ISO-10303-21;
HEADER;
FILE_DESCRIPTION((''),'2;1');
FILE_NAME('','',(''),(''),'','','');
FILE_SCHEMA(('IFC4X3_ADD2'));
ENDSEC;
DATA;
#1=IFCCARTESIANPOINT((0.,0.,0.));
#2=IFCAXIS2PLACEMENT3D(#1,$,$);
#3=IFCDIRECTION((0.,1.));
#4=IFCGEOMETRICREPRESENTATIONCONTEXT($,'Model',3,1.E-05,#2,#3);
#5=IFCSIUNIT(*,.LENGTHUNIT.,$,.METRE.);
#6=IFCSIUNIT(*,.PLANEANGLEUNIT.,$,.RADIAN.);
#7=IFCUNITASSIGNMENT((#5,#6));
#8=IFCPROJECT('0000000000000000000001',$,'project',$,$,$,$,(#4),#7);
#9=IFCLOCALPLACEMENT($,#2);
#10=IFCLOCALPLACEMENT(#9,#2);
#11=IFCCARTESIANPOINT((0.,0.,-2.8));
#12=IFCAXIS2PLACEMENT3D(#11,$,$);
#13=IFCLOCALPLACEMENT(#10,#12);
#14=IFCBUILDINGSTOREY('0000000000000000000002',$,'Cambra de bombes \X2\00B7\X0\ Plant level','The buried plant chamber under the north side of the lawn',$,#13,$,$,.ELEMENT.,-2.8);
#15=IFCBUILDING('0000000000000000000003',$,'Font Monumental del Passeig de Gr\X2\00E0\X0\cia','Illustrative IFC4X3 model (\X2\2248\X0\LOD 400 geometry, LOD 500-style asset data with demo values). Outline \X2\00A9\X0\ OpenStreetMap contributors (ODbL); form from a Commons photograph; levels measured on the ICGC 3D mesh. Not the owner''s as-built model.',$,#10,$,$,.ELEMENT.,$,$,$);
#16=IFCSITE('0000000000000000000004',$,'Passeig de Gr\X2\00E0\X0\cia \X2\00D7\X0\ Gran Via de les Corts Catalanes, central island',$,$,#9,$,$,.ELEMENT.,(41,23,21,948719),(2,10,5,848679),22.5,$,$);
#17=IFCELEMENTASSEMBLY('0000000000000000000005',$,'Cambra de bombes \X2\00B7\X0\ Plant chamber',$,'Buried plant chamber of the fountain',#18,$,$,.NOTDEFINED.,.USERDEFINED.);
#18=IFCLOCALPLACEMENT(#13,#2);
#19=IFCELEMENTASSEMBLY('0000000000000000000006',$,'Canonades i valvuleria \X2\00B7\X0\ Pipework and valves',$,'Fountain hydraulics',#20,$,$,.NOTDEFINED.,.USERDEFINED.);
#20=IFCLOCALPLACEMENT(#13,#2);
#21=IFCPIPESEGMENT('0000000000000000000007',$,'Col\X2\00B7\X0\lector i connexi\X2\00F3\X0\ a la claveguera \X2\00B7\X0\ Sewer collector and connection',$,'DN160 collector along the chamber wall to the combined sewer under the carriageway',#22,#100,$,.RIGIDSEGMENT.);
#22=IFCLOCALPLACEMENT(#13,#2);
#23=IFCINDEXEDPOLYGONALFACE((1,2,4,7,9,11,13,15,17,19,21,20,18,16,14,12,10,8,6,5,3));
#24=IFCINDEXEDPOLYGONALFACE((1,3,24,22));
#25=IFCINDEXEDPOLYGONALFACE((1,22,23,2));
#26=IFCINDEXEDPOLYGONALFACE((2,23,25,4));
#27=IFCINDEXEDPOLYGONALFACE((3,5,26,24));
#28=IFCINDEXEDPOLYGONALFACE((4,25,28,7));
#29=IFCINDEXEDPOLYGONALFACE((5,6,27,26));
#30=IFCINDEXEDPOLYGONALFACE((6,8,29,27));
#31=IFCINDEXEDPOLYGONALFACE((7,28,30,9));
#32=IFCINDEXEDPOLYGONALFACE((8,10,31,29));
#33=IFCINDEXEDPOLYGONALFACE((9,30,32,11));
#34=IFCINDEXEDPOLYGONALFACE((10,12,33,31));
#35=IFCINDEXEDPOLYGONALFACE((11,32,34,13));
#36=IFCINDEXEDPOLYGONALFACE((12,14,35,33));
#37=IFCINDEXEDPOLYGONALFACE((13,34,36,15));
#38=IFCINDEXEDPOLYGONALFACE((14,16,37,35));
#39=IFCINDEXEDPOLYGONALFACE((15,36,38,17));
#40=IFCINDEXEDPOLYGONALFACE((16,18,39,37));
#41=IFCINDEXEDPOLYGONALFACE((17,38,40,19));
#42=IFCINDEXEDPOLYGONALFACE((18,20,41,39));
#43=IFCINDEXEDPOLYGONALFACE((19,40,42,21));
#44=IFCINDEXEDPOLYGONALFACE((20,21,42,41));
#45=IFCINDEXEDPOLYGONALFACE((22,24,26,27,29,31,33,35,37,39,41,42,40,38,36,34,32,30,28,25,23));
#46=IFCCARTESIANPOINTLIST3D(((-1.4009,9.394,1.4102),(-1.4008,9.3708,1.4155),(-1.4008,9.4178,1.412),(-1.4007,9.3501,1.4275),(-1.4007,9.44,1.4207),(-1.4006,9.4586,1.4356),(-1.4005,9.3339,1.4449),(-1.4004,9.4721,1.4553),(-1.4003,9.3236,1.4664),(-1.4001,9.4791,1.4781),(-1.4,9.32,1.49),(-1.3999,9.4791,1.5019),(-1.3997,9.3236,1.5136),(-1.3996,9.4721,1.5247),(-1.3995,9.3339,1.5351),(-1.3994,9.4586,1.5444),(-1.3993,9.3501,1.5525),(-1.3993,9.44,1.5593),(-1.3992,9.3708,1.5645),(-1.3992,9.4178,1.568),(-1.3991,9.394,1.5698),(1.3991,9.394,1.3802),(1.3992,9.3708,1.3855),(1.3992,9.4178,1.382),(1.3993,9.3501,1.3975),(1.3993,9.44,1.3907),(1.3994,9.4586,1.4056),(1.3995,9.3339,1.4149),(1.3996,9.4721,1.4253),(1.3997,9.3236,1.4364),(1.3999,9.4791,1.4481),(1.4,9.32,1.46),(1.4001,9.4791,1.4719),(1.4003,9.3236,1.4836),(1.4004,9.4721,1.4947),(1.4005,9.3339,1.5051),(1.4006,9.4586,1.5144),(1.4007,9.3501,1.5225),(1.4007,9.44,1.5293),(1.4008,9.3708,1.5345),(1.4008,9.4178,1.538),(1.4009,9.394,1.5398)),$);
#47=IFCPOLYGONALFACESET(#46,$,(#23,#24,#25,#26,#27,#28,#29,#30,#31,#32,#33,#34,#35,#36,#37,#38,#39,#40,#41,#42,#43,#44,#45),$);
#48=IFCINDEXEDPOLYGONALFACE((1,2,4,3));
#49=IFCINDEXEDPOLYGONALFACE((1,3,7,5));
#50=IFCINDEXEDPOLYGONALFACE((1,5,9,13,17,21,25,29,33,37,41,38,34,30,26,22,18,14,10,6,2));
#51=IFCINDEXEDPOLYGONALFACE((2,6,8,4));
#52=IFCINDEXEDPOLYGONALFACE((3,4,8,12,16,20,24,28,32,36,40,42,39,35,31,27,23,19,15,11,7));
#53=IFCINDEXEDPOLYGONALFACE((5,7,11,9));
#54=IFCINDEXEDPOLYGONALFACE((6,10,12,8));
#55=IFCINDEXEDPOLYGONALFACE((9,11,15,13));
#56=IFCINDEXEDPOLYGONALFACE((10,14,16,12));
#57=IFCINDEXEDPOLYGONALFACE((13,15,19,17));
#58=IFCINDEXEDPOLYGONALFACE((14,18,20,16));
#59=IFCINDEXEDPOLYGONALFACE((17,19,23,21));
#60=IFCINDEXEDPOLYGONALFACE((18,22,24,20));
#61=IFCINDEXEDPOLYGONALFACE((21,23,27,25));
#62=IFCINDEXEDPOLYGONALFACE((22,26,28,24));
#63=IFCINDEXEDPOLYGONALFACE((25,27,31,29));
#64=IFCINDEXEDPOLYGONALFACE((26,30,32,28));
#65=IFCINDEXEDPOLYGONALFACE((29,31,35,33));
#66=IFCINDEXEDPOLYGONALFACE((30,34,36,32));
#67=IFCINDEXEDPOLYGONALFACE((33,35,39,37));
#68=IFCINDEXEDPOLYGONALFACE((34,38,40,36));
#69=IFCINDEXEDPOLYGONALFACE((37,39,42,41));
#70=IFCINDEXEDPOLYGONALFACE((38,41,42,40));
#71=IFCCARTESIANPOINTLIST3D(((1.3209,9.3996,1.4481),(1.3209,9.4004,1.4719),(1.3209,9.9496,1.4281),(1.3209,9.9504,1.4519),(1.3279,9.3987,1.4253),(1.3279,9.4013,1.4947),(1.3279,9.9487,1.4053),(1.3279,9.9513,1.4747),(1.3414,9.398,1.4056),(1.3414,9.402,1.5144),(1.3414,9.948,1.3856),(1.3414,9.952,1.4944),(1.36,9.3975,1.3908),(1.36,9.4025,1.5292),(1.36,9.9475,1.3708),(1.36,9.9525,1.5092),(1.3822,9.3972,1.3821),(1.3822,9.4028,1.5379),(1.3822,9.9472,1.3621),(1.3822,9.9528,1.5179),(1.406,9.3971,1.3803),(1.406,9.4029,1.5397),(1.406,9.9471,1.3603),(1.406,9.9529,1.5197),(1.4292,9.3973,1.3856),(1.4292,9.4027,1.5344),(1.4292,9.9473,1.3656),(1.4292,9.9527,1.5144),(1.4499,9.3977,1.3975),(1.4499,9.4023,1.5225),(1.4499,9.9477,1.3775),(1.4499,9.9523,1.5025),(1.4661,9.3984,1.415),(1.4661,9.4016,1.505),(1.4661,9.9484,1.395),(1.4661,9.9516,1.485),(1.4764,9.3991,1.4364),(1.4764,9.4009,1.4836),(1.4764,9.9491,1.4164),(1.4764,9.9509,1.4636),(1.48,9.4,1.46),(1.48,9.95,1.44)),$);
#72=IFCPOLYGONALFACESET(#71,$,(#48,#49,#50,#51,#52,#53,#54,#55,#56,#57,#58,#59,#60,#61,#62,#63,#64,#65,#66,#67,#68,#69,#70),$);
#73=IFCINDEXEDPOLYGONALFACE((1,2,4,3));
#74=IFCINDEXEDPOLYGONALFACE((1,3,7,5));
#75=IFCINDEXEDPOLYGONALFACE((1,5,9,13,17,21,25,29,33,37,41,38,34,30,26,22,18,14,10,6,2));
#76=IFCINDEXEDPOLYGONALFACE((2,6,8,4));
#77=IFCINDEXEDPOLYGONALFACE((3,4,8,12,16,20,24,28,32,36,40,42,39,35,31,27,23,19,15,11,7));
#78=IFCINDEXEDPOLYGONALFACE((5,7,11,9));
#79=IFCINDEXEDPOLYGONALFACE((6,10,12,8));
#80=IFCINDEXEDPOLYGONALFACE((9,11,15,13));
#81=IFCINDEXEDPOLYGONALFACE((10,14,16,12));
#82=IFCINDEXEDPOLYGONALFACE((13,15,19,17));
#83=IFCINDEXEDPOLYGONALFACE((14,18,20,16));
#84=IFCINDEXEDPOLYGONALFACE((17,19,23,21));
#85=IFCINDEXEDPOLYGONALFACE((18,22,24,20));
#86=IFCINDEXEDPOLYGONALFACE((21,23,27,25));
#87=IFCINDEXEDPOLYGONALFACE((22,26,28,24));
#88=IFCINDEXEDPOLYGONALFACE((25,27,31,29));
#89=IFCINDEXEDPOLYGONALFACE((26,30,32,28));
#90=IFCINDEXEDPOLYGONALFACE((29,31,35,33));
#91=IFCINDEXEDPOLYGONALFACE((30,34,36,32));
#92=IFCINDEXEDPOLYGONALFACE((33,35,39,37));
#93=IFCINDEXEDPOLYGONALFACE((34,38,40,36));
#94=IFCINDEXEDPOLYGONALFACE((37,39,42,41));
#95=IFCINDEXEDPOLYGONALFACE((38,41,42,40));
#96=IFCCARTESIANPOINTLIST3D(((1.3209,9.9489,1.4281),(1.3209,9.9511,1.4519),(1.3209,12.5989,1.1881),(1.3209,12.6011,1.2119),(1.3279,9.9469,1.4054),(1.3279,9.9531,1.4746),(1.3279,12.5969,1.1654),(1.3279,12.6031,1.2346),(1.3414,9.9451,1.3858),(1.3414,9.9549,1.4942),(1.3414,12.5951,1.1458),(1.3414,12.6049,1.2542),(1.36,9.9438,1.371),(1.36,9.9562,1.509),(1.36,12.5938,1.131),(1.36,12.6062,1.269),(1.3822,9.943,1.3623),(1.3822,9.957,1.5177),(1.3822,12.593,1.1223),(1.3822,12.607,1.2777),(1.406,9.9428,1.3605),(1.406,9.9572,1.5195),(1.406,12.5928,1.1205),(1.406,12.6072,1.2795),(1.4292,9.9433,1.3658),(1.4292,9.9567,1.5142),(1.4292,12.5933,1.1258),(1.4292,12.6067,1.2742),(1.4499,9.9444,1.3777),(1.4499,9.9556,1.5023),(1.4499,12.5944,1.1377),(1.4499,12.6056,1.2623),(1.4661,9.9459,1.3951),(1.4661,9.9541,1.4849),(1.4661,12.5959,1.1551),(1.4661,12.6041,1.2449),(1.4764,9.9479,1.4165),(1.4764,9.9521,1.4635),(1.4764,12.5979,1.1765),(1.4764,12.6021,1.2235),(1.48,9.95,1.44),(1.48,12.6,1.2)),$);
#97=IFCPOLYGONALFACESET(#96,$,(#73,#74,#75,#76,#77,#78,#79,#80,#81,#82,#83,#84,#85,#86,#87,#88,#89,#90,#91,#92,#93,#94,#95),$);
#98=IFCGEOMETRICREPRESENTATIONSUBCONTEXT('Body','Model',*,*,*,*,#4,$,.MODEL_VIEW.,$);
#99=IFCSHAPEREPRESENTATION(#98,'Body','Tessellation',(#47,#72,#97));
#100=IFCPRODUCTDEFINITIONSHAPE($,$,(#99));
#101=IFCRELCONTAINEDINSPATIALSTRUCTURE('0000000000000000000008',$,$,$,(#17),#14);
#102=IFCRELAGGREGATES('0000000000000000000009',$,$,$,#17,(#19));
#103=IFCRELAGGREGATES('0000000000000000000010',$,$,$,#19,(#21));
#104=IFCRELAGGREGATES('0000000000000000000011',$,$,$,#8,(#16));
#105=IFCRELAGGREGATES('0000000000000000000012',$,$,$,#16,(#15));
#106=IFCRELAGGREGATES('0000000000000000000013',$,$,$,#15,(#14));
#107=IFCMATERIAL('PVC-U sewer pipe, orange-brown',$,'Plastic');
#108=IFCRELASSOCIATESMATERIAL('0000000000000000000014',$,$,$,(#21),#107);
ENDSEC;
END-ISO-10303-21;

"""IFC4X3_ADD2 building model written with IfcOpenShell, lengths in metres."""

from ifc_helpers import new_model, si_unit, direction, frame, origin, origin_2d_with_axis, place, context, subcontext, project, spatial, circle, extrude, material, element, aggregate, save


model = new_model("IFC4X3_ADD2")

# Units and contexts
model_context = context("Model", 3, precision=1e-05, world=origin(), true_north=direction((0.0, 1.0)))
body_context = subcontext(model_context, "Body", "Model", "MODEL_VIEW")
ifc_project = project(units=[si_unit("LENGTHUNIT", "METRE"), si_unit("PLANEANGLEUNIT", "RADIAN")], contexts=[model_context])

# Site, building, storey
site_placement = place(None, origin())
site = spatial("IfcSite", under=ifc_project, at=site_placement, Name="Passeig de Gràcia × Gran Via de les Corts Catalanes, central island", CompositionType="ELEMENT", RefLatitude=(41, 23, 21, 948719), RefLongitude=(2, 10, 5, 848679), RefElevation=22.5)
building_placement = place(site_placement, origin())
building = spatial("IfcBuilding", under=site, at=building_placement, Name="Font Monumental del Passeig de Gràcia", Description="Illustrative IFC4X3 model (≈LOD 400 geometry, LOD 500-style asset data with demo values). Outline © OpenStreetMap contributors (ODbL); form from a Commons photograph; levels measured on the ICGC 3D mesh. Not the owner's as-built model.", CompositionType="ELEMENT")
storey_placement = place(building_placement, frame((0.0, 0.0, -2.8)))
storey = spatial("IfcBuildingStorey", under=building, at=storey_placement, Name="Cambra de bombes · Plant level", Description="The buried plant chamber under the north side of the lawn", CompositionType="ELEMENT", Elevation=-2.8)

# Element assemblies, pipe segment
assembly_1_placement = place(building_placement, origin())
assembly_1 = element("IfcElementAssembly", 1, at=assembly_1_placement, inside=storey, Name="Cambra de bombes · Plant chamber", ObjectType="Buried plant chamber of the fountain", AssemblyPlace="NOTDEFINED", PredefinedType="USERDEFINED")
assembly_2_placement = place(building_placement, origin())
assembly_2 = element("IfcElementAssembly", 2, at=assembly_2_placement, Name="Canonades i valvuleria · Pipework and valves", ObjectType="Fountain hydraulics", AssemblyPlace="NOTDEFINED", PredefinedType="USERDEFINED")
aggregate(assembly_1, [assembly_2])
ifc_material_1 = material(Name="PVC-U sewer pipe, orange-brown", Category="Plastic")
pipe_segment_1_placement = place(building_placement, origin())
pipe_segment_1 = element("IfcPipeSegment", 3, at=pipe_segment_1_placement, material=ifc_material_1, Name="Col·lector i connexió a la claveguera · Sewer collector and connection", ObjectType="DN160 collector along the chamber wall to the combined sewer under the carriageway", PredefinedType="RIGIDSEGMENT", context=body_context, shape_type="SweptSolid", body=[
    extrude(circle(Radius=0.08, at=origin_2d_with_axis()), frame((-1.4, 9.4, -1.31), z_axis=(0.999943, 0.0, -0.010714), x_axis=(0.0, -1.0, 0.0)), (0.0, 0.0, 1.0), 2.8002),
    extrude(circle(Radius=0.08, at=origin_2d_with_axis()), frame((1.4, 9.4, -1.34), z_axis=(0.0, 0.999339, -0.03634), x_axis=(1.0, 0.0, 0.0)), (0.0, 0.0, 1.0), 0.5504),
    extrude(circle(Radius=0.08, at=origin_2d_with_axis()), frame((1.4, 9.95, -1.36), z_axis=(0.0, 0.995924, -0.090197), x_axis=(1.0, 0.0, 0.0)), (0.0, 0.0, 1.0), 2.6608),
])
aggregate(assembly_2, [pipe_segment_1])

save(model, "model.ifc")
